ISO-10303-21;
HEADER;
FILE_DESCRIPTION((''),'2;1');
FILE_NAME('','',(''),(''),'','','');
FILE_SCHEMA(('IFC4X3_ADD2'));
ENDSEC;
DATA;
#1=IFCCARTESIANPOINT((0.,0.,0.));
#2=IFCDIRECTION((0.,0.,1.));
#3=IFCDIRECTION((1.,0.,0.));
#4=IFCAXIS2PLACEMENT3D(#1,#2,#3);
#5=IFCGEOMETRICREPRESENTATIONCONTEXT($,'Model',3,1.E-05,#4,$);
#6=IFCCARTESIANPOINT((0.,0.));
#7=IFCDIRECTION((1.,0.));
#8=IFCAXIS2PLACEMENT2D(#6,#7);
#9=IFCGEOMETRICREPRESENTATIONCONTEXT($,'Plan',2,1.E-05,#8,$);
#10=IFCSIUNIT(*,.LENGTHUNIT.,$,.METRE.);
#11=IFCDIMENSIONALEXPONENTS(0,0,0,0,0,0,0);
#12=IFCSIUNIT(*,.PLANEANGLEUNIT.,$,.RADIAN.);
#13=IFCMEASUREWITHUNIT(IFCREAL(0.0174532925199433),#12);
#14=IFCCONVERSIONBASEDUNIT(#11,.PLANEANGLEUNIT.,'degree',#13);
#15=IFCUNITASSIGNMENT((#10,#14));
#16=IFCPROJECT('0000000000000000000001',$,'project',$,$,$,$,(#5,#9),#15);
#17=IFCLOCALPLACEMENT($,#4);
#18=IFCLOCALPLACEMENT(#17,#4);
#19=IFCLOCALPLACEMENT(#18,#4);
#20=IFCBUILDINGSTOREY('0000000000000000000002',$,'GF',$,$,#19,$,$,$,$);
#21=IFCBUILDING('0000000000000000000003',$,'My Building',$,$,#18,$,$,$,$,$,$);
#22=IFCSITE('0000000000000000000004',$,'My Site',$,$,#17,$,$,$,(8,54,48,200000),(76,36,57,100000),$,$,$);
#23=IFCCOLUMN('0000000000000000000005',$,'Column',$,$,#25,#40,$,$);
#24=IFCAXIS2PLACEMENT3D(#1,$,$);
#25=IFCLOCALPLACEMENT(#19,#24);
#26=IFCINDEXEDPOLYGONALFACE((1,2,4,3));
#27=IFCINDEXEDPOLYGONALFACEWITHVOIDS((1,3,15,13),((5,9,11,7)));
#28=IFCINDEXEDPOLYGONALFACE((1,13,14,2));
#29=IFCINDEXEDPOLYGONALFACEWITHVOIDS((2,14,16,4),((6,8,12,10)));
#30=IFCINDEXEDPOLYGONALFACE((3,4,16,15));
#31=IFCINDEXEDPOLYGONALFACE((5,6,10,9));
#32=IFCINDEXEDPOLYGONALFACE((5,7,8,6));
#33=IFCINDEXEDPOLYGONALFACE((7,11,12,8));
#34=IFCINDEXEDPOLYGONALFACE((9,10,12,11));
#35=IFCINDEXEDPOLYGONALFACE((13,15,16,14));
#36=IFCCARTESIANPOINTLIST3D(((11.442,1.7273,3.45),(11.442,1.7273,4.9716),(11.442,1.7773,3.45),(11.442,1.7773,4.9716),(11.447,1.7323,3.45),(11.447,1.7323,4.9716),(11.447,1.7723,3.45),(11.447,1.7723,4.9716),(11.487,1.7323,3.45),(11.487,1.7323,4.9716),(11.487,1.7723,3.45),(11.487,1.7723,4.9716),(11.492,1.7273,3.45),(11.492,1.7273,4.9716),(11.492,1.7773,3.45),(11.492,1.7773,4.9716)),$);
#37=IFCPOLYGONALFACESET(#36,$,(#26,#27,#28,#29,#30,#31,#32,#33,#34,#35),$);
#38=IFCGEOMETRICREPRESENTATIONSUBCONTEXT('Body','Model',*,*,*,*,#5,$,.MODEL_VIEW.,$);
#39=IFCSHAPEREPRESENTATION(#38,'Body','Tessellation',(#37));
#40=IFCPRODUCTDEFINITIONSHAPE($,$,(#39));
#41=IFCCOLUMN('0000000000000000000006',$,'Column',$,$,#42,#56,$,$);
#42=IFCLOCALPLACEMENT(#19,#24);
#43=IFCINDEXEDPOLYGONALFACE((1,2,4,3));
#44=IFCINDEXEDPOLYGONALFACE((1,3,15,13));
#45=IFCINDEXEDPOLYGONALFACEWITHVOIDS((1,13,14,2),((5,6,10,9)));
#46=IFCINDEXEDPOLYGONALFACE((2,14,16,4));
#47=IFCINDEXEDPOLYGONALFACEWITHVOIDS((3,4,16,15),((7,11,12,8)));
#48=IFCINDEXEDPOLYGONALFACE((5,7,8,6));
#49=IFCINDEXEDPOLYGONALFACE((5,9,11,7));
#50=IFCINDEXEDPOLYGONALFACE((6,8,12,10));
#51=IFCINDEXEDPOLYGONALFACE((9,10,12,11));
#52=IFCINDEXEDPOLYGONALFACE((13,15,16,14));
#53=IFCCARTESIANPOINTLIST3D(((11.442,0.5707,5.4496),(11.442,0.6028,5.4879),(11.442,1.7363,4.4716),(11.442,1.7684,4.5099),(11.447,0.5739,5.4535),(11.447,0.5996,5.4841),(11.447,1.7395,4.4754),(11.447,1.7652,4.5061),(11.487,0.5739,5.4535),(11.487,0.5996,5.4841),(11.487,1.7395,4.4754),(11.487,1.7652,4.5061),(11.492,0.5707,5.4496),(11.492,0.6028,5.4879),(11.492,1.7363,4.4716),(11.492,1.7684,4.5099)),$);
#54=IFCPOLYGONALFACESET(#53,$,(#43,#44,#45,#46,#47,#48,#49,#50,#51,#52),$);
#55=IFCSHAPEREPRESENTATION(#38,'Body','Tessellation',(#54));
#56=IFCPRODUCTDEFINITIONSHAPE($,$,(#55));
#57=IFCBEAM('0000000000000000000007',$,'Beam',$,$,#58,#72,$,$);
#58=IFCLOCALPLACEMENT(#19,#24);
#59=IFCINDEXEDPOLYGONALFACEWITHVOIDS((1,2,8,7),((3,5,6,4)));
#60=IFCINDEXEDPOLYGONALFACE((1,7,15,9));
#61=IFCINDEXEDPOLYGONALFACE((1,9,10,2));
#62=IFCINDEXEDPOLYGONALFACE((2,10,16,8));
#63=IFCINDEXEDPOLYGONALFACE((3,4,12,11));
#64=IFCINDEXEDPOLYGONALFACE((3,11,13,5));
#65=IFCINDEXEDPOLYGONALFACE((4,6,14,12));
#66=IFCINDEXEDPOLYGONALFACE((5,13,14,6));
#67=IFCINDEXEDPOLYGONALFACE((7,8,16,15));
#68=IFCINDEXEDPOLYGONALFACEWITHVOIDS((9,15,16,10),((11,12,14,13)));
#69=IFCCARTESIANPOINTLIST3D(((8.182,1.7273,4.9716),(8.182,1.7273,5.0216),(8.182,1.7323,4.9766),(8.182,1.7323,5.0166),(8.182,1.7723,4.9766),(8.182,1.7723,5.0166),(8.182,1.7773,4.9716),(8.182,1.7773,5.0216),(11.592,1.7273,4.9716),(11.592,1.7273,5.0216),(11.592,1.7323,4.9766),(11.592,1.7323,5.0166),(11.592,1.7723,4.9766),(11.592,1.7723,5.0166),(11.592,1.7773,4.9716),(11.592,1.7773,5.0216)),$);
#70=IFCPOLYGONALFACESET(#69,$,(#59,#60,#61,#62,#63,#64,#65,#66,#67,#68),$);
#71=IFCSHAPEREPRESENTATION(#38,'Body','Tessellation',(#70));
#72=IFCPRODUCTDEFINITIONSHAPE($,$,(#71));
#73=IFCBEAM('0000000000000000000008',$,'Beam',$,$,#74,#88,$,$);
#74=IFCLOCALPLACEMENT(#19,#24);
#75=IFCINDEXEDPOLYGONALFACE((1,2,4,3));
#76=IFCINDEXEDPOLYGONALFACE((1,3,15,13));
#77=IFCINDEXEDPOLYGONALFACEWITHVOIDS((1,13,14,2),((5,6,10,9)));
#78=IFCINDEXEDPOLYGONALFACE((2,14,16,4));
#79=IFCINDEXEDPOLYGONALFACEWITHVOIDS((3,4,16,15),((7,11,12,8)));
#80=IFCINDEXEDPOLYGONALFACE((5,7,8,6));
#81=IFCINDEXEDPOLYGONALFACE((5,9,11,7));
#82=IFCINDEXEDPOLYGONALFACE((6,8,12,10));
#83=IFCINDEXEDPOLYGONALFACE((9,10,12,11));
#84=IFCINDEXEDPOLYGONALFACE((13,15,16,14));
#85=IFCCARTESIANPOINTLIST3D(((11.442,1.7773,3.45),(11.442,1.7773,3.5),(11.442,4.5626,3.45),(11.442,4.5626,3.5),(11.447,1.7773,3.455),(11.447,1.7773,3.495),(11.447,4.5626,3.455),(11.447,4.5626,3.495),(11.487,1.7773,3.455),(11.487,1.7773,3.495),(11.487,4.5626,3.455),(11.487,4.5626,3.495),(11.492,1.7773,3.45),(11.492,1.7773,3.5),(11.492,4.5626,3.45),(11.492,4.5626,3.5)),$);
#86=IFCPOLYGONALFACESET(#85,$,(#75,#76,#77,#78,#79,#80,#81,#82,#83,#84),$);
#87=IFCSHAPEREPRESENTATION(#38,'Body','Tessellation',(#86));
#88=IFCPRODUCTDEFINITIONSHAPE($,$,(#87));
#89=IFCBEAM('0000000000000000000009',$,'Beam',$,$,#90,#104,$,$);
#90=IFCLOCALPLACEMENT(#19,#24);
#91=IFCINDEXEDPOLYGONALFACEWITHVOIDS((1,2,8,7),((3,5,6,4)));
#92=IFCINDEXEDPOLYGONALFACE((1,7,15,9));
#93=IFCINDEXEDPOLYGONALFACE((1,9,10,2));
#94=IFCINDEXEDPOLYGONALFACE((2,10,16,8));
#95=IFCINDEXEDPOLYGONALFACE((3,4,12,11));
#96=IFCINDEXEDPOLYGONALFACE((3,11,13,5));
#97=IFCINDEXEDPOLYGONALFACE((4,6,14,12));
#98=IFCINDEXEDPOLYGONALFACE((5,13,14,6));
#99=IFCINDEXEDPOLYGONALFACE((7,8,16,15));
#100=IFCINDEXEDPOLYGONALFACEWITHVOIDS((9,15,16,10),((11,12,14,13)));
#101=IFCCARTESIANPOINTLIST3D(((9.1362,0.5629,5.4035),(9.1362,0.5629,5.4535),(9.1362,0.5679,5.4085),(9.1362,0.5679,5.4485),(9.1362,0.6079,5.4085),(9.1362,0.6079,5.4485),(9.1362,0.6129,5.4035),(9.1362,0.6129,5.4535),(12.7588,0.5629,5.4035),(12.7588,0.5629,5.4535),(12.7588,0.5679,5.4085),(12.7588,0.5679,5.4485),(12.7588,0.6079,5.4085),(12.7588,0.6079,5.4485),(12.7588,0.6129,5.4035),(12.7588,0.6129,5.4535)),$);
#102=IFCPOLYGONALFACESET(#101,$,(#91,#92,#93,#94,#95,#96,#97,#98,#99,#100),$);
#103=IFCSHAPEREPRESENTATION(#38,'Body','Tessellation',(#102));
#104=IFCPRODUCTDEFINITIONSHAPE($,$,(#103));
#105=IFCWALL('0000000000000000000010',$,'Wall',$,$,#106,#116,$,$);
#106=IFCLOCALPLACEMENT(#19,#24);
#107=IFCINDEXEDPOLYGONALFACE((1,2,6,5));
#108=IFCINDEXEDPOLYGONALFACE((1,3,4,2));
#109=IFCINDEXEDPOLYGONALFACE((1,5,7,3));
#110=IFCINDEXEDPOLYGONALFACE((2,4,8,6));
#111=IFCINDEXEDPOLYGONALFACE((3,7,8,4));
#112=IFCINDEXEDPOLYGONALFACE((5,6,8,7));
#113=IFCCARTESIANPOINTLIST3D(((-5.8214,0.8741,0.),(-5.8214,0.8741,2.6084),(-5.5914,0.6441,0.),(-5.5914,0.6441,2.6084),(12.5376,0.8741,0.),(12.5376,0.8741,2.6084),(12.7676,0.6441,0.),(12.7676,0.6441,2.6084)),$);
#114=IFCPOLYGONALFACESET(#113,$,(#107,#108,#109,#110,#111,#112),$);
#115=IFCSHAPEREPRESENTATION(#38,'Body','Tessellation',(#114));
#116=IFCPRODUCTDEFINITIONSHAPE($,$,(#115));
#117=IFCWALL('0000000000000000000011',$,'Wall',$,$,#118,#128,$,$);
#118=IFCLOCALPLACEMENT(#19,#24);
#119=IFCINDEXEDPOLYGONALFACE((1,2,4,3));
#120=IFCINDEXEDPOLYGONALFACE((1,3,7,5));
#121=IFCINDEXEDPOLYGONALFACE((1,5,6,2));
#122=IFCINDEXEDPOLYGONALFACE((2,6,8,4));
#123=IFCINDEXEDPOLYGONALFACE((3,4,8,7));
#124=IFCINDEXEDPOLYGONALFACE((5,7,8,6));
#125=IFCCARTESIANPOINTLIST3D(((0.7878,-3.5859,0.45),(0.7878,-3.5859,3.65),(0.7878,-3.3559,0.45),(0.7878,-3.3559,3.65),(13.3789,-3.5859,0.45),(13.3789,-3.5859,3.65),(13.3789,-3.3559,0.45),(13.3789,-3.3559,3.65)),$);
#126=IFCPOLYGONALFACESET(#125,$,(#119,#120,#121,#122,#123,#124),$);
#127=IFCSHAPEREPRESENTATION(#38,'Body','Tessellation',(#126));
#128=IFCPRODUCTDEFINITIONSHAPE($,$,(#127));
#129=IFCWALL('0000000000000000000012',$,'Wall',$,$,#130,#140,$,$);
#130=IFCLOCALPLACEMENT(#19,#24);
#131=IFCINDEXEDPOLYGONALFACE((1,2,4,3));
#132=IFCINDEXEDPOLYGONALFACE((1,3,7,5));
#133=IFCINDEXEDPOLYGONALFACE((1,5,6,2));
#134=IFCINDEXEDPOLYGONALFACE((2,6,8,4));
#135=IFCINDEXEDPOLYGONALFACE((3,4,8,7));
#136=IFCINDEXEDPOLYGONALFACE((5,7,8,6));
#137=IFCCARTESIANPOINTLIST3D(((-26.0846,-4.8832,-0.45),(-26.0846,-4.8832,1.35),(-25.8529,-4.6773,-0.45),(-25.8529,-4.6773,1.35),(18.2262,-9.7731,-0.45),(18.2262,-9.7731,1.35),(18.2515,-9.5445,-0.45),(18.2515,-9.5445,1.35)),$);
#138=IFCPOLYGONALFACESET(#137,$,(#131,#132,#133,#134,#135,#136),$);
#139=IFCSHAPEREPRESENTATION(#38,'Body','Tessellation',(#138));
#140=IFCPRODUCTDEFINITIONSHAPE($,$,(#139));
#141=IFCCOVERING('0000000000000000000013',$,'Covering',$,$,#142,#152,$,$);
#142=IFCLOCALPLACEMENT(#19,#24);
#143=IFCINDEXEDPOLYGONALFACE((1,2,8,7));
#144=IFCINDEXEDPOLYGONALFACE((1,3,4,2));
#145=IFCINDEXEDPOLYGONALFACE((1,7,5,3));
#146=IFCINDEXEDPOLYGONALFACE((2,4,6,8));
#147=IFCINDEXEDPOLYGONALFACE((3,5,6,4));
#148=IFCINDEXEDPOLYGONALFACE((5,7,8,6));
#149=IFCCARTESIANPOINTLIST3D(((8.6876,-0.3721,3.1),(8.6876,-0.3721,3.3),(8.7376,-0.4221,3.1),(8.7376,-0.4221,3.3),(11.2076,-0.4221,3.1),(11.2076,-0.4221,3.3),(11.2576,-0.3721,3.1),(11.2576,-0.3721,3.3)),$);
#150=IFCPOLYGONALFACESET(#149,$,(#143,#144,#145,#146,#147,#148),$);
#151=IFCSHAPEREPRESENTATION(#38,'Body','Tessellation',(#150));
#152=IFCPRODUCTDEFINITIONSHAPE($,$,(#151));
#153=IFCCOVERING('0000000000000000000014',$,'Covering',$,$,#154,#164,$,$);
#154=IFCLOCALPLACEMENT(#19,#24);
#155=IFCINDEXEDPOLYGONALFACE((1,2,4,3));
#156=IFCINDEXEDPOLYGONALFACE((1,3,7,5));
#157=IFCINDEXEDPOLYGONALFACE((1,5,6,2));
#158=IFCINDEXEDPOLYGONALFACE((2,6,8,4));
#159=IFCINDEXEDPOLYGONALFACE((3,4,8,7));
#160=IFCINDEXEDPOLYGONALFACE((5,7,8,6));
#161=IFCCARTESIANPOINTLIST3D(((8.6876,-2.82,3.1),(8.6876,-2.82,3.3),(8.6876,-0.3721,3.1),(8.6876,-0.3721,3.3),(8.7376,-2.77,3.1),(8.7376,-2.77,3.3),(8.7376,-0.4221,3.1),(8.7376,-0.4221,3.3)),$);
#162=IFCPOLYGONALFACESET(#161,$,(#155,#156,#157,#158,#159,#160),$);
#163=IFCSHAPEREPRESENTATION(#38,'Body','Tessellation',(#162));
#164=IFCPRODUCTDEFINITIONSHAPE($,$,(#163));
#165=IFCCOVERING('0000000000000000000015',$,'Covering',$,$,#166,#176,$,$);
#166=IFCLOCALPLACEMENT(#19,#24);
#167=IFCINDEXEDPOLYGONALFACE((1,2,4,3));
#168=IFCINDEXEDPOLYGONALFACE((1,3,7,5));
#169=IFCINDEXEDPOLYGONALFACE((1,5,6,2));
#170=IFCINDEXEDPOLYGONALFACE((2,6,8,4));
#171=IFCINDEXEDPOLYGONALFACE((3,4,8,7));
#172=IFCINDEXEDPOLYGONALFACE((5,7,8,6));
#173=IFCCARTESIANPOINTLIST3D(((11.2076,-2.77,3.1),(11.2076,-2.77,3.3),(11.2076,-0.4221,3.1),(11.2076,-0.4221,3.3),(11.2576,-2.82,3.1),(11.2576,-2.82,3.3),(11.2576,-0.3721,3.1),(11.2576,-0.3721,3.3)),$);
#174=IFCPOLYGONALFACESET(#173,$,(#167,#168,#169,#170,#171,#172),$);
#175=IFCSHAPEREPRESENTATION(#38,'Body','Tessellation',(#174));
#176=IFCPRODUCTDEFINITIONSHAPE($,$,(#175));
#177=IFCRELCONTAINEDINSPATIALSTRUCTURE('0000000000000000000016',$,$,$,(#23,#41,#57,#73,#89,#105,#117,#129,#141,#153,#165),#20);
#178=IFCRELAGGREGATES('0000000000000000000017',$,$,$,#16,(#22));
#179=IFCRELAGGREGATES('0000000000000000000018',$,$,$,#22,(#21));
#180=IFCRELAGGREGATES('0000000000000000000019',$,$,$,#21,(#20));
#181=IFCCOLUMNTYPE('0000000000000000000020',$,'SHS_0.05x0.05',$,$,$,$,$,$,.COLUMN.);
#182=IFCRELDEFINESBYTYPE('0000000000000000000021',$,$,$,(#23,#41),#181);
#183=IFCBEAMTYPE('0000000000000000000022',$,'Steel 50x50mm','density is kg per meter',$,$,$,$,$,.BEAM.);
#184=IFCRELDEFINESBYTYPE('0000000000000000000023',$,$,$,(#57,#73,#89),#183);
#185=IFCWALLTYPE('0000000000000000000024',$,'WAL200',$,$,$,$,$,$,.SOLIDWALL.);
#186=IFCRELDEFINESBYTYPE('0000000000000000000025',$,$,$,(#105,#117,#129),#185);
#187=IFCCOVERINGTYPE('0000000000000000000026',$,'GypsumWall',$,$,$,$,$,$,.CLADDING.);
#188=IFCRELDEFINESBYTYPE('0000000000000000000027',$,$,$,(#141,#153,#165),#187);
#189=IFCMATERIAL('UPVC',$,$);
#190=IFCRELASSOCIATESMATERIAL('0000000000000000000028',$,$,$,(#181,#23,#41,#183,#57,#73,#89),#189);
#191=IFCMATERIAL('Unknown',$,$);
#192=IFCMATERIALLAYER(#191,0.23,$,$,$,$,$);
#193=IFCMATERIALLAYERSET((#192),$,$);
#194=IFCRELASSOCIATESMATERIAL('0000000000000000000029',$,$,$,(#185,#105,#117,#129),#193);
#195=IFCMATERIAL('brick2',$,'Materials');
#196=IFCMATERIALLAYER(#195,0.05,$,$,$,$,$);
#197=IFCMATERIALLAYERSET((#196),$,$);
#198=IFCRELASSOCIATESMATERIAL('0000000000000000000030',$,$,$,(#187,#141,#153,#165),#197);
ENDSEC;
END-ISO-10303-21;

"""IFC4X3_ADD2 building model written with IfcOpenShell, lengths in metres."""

from ifc_helpers import new_model, entity, si_unit, converted_unit, frame, origin_with_axes, origin_2d_with_axis, place, context, subcontext, project, spatial, line, indexed_curve, hollow_rectangle, outline, extrude, material, layer, layer_set, layer_usage, material_profile, profile_set, profile_usage, type_object, element, save


model = new_model("IFC4X3_ADD2")

# Units and contexts
model_context = context("Model", 3, precision=1e-05, world=origin_with_axes())
plan_context = context("Plan", 2, precision=1e-05, world=origin_2d_with_axis())
body_context = subcontext(model_context, "Body", "Model", "MODEL_VIEW")
ifc_project = project(units=[si_unit("LENGTHUNIT", "METRE"), converted_unit("PLANEANGLEUNIT", "degree", entity("IfcReal", 0.0174532925199433), si_unit("PLANEANGLEUNIT", "RADIAN"), dimensions=[0, 0, 0, 0, 0, 0, 0])], contexts=[model_context, plan_context])

# Site, building, storey
site_placement = place(None, origin_with_axes())
site = spatial("IfcSite", under=ifc_project, at=site_placement, Name="My Site", RefLatitude=(8, 54, 48, 200000), RefLongitude=(76, 36, 57, 100000))
building_placement = place(site_placement, origin_with_axes())
building = spatial("IfcBuilding", under=site, at=building_placement, Name="My Building")
storey_placement = place(building_placement, origin_with_axes())
storey = spatial("IfcBuildingStorey", under=building, at=storey_placement, Name="GF")

# Columns
ifc_material_1 = material(Name="UPVC")
ifc_material_profile_1 = material_profile(ifc_material_1, hollow_rectangle(XDim=0.05, YDim=0.05, WallThickness=0.005))
ifc_profile_set_1 = profile_set([ifc_material_profile_1])
ifc_profile_usage_1 = profile_usage(ifc_profile_set_1, cardinal=5)
column_type = type_object("IfcColumnType", Name="SHS_0.05x0.05", PredefinedType="COLUMN", material=ifc_profile_set_1)
column_1_placement = place(storey_placement, frame((11.467, 1.7523, 3.45), z_axis=(0.0, 0.0, 1.0), x_axis=(1.0, 0.0, 0.0)))
element("IfcColumn", 1, at=column_1_placement, inside=storey, type_object=column_type, material=ifc_profile_usage_1, Name="Column", context=body_context, shape_type="SweptSolid", body=[
    extrude(hollow_rectangle(XDim=0.05, YDim=0.05, WallThickness=0.005), origin_with_axes(), (0.0, 0.0, 1.0), 1.5216),
])
ifc_profile_usage_2 = profile_usage(ifc_profile_set_1, cardinal=5)
column_2_placement = place(storey_placement, frame((11.467, 1.7523, 4.4907), z_axis=(0.0, -0.766045, 0.642788), x_axis=(1.0, 0.0, 0.0)))
element("IfcColumn", 2, at=column_2_placement, inside=storey, type_object=column_type, material=ifc_profile_usage_2, Name="Column", context=body_context, shape_type="SweptSolid", body=[
    extrude(hollow_rectangle(XDim=0.05, YDim=0.05, WallThickness=0.005), origin_with_axes(), (0.0, 0.0, 1.0), 1.5216),
])

# Beams
ifc_material_profile_2 = material_profile(ifc_material_1, hollow_rectangle(XDim=0.05, YDim=0.05, WallThickness=0.005))
ifc_profile_set_2 = profile_set([ifc_material_profile_2])
ifc_profile_usage_3 = profile_usage(ifc_profile_set_2, cardinal=5)
beam_type = type_object("IfcBeamType", Name="Steel 50x50mm", Description="density is kg per meter", PredefinedType="BEAM", material=ifc_profile_set_2)
beam_1_placement = place(storey_placement, frame((11.592, 1.7523, 4.9966), z_axis=(-1.0, 0.0, 0.0), x_axis=(0.0, -1.0, 0.0)))
element("IfcBeam", 3, at=beam_1_placement, inside=storey, type_object=beam_type, material=ifc_profile_usage_3, Name="Beam", context=body_context, shape_type="SweptSolid", body=[
    extrude(hollow_rectangle(XDim=0.05, YDim=0.05, WallThickness=0.005), origin_with_axes(), (0.0, 0.0, 1.0), 3.41),
])
ifc_profile_usage_4 = profile_usage(ifc_profile_set_2, cardinal=5)
beam_2_placement = place(storey_placement, frame((11.467, 1.7773, 3.475), z_axis=(0.0, 1.0, 0.0), x_axis=(-1.0, 0.0, 0.0)))
element("IfcBeam", 4, at=beam_2_placement, inside=storey, type_object=beam_type, material=ifc_profile_usage_4, Name="Beam", context=body_context, shape_type="SweptSolid", body=[
    extrude(hollow_rectangle(XDim=0.05, YDim=0.05, WallThickness=0.005), origin_with_axes(), (0.0, 0.0, 1.0), 2.7852),
])
ifc_profile_usage_5 = profile_usage(ifc_profile_set_2, cardinal=5)
beam_3_placement = place(storey_placement, frame((12.7588, 0.5879, 5.4285), z_axis=(-1.0, 0.0, 0.0), x_axis=(0.0, -1.0, 0.0)))
element("IfcBeam", 5, at=beam_3_placement, inside=storey, type_object=beam_type, material=ifc_profile_usage_5, Name="Beam", context=body_context, shape_type="SweptSolid", body=[
    extrude(hollow_rectangle(XDim=0.05, YDim=0.05, WallThickness=0.005), origin_with_axes(), (0.0, 0.0, 1.0), 3.6226),
])

# Walls
ifc_material_2 = material(Name="Unknown")
ifc_layer_1 = layer(ifc_material_2, 0.23)
ifc_layer_set_1 = layer_set([ifc_layer_1])
ifc_layer_usage_1 = layer_usage(ifc_layer_set_1, "AXIS2", "POSITIVE", 0.0)
wall_type = type_object("IfcWallType", Name="WAL200", PredefinedType="SOLIDWALL", material=ifc_layer_set_1)
wall_1_placement = place(storey_placement, frame((12.5376, 0.8741, 0.0), z_axis=(0.0, 0.0, 1.0), x_axis=(-1.0, 0.0, 0.0)))
element("IfcWall", 6, at=wall_1_placement, inside=storey, type_object=wall_type, material=ifc_layer_usage_1, Name="Wall", context=body_context, shape_type="SweptSolid", body=[
    extrude(outline(indexed_curve([(0.0, 0.0), (-0.23, 0.23), (18.129, 0.23), (18.359, 0.0)], segments=[line(1, 2, 3, 4, 1)])), origin_with_axes(), (0.0, 0.0, 1.0), 2.6084),
])
ifc_layer_usage_2 = layer_usage(ifc_layer_set_1, "AXIS2", "POSITIVE", 0.0)
wall_2_placement = place(storey_placement, frame((13.3789, -3.3559, 0.45), z_axis=(0.0, 0.0, 1.0), x_axis=(-1.0, 0.0, 0.0)))
element("IfcWall", 7, at=wall_2_placement, inside=storey, type_object=wall_type, material=ifc_layer_usage_2, Name="Wall", context=body_context, shape_type="SweptSolid", body=[
    extrude(outline(indexed_curve([(0.0, 0.0), (0.0, 0.23), (12.5911, 0.23), (12.5911, 0.0)], segments=[line(1, 2, 3, 4, 1)])), origin_with_axes(), (0.0, 0.0, 1.0), 3.2),
])

# Wall
ifc_layer_usage_3 = layer_usage(ifc_layer_set_1, "AXIS2", "NEGATIVE", 0.0)
wall_3_placement = place(storey_placement, frame((18.2262, -9.7731, -0.45), z_axis=(0.0, 0.0, 1.0), x_axis=(-0.993966, 0.10969, 0.0)))
element("IfcWall", 8, at=wall_3_placement, inside=storey, type_object=wall_type, material=ifc_layer_usage_3, Name="Wall", context=body_context, shape_type="SweptSolid", body=[
    extrude(outline(indexed_curve([(0.0, -0.23), (0.0, 0.0), (44.5798, 0.0), (44.3721, -0.23)], segments=[line(1, 2, 3, 4, 1)])), origin_with_axes(), (0.0, 0.0, 1.0), 1.8),
])

# Coverings
ifc_material_3 = material(Name="brick2", Category="Materials")
ifc_layer_2 = layer(ifc_material_3, 0.05)
ifc_layer_set_2 = layer_set([ifc_layer_2])
ifc_layer_usage_4 = layer_usage(ifc_layer_set_2, "AXIS2", "POSITIVE", 0.0)
covering_type = type_object("IfcCoveringType", Name="GypsumWall", PredefinedType="CLADDING", material=ifc_layer_set_2)
covering_1_placement = place(storey_placement, frame((8.6876, -0.4221, 3.1), z_axis=(0.0, 0.0, 1.0), x_axis=(1.0, 0.0, 0.0)))
element("IfcCovering", 9, at=covering_1_placement, inside=storey, type_object=covering_type, material=ifc_layer_usage_4, Name="Covering", context=body_context, shape_type="SweptSolid", body=[
    extrude(outline(indexed_curve([(0.05, 0.0), (0.0, 0.05), (2.57, 0.05), (2.52, 0.0)], segments=[line(1, 2, 3, 4, 1)])), origin_with_axes(), (0.0, 0.0, 1.0), 0.2),
])
ifc_layer_usage_5 = layer_usage(ifc_layer_set_2, "AXIS2", "POSITIVE", 0.0)
covering_2_placement = place(storey_placement, frame((8.6876, -0.4221, 3.1), z_axis=(0.0, 0.0, 1.0), x_axis=(0.0, -1.0, 0.0)))
element("IfcCovering", 10, at=covering_2_placement, inside=storey, type_object=covering_type, material=ifc_layer_usage_5, Name="Covering", context=body_context, shape_type="SweptSolid", body=[
    extrude(outline(indexed_curve([(-0.05, 0.0), (0.0, 0.05), (2.3479, 0.05), (2.3979, 0.0)], segments=[line(1, 2, 3, 4, 1)])), origin_with_axes(), (0.0, 0.0, 1.0), 0.2),
])
ifc_layer_usage_6 = layer_usage(ifc_layer_set_2, "AXIS2", "POSITIVE", 0.0)
covering_3_placement = place(storey_placement, frame((11.2076, -0.4221, 3.1), z_axis=(0.0, 0.0, 1.0), x_axis=(0.0, -1.0, 0.0)))
element("IfcCovering", 11, at=covering_3_placement, inside=storey, type_object=covering_type, material=ifc_layer_usage_6, Name="Covering", context=body_context, shape_type="SweptSolid", body=[
    extrude(outline(indexed_curve([(0.0, 0.0), (-0.05, 0.05), (2.3979, 0.05), (2.3479, 0.0)], segments=[line(1, 2, 3, 4, 1)])), origin_with_axes(), (0.0, 0.0, 1.0), 0.2),
])

save(model, "model.ifc")
